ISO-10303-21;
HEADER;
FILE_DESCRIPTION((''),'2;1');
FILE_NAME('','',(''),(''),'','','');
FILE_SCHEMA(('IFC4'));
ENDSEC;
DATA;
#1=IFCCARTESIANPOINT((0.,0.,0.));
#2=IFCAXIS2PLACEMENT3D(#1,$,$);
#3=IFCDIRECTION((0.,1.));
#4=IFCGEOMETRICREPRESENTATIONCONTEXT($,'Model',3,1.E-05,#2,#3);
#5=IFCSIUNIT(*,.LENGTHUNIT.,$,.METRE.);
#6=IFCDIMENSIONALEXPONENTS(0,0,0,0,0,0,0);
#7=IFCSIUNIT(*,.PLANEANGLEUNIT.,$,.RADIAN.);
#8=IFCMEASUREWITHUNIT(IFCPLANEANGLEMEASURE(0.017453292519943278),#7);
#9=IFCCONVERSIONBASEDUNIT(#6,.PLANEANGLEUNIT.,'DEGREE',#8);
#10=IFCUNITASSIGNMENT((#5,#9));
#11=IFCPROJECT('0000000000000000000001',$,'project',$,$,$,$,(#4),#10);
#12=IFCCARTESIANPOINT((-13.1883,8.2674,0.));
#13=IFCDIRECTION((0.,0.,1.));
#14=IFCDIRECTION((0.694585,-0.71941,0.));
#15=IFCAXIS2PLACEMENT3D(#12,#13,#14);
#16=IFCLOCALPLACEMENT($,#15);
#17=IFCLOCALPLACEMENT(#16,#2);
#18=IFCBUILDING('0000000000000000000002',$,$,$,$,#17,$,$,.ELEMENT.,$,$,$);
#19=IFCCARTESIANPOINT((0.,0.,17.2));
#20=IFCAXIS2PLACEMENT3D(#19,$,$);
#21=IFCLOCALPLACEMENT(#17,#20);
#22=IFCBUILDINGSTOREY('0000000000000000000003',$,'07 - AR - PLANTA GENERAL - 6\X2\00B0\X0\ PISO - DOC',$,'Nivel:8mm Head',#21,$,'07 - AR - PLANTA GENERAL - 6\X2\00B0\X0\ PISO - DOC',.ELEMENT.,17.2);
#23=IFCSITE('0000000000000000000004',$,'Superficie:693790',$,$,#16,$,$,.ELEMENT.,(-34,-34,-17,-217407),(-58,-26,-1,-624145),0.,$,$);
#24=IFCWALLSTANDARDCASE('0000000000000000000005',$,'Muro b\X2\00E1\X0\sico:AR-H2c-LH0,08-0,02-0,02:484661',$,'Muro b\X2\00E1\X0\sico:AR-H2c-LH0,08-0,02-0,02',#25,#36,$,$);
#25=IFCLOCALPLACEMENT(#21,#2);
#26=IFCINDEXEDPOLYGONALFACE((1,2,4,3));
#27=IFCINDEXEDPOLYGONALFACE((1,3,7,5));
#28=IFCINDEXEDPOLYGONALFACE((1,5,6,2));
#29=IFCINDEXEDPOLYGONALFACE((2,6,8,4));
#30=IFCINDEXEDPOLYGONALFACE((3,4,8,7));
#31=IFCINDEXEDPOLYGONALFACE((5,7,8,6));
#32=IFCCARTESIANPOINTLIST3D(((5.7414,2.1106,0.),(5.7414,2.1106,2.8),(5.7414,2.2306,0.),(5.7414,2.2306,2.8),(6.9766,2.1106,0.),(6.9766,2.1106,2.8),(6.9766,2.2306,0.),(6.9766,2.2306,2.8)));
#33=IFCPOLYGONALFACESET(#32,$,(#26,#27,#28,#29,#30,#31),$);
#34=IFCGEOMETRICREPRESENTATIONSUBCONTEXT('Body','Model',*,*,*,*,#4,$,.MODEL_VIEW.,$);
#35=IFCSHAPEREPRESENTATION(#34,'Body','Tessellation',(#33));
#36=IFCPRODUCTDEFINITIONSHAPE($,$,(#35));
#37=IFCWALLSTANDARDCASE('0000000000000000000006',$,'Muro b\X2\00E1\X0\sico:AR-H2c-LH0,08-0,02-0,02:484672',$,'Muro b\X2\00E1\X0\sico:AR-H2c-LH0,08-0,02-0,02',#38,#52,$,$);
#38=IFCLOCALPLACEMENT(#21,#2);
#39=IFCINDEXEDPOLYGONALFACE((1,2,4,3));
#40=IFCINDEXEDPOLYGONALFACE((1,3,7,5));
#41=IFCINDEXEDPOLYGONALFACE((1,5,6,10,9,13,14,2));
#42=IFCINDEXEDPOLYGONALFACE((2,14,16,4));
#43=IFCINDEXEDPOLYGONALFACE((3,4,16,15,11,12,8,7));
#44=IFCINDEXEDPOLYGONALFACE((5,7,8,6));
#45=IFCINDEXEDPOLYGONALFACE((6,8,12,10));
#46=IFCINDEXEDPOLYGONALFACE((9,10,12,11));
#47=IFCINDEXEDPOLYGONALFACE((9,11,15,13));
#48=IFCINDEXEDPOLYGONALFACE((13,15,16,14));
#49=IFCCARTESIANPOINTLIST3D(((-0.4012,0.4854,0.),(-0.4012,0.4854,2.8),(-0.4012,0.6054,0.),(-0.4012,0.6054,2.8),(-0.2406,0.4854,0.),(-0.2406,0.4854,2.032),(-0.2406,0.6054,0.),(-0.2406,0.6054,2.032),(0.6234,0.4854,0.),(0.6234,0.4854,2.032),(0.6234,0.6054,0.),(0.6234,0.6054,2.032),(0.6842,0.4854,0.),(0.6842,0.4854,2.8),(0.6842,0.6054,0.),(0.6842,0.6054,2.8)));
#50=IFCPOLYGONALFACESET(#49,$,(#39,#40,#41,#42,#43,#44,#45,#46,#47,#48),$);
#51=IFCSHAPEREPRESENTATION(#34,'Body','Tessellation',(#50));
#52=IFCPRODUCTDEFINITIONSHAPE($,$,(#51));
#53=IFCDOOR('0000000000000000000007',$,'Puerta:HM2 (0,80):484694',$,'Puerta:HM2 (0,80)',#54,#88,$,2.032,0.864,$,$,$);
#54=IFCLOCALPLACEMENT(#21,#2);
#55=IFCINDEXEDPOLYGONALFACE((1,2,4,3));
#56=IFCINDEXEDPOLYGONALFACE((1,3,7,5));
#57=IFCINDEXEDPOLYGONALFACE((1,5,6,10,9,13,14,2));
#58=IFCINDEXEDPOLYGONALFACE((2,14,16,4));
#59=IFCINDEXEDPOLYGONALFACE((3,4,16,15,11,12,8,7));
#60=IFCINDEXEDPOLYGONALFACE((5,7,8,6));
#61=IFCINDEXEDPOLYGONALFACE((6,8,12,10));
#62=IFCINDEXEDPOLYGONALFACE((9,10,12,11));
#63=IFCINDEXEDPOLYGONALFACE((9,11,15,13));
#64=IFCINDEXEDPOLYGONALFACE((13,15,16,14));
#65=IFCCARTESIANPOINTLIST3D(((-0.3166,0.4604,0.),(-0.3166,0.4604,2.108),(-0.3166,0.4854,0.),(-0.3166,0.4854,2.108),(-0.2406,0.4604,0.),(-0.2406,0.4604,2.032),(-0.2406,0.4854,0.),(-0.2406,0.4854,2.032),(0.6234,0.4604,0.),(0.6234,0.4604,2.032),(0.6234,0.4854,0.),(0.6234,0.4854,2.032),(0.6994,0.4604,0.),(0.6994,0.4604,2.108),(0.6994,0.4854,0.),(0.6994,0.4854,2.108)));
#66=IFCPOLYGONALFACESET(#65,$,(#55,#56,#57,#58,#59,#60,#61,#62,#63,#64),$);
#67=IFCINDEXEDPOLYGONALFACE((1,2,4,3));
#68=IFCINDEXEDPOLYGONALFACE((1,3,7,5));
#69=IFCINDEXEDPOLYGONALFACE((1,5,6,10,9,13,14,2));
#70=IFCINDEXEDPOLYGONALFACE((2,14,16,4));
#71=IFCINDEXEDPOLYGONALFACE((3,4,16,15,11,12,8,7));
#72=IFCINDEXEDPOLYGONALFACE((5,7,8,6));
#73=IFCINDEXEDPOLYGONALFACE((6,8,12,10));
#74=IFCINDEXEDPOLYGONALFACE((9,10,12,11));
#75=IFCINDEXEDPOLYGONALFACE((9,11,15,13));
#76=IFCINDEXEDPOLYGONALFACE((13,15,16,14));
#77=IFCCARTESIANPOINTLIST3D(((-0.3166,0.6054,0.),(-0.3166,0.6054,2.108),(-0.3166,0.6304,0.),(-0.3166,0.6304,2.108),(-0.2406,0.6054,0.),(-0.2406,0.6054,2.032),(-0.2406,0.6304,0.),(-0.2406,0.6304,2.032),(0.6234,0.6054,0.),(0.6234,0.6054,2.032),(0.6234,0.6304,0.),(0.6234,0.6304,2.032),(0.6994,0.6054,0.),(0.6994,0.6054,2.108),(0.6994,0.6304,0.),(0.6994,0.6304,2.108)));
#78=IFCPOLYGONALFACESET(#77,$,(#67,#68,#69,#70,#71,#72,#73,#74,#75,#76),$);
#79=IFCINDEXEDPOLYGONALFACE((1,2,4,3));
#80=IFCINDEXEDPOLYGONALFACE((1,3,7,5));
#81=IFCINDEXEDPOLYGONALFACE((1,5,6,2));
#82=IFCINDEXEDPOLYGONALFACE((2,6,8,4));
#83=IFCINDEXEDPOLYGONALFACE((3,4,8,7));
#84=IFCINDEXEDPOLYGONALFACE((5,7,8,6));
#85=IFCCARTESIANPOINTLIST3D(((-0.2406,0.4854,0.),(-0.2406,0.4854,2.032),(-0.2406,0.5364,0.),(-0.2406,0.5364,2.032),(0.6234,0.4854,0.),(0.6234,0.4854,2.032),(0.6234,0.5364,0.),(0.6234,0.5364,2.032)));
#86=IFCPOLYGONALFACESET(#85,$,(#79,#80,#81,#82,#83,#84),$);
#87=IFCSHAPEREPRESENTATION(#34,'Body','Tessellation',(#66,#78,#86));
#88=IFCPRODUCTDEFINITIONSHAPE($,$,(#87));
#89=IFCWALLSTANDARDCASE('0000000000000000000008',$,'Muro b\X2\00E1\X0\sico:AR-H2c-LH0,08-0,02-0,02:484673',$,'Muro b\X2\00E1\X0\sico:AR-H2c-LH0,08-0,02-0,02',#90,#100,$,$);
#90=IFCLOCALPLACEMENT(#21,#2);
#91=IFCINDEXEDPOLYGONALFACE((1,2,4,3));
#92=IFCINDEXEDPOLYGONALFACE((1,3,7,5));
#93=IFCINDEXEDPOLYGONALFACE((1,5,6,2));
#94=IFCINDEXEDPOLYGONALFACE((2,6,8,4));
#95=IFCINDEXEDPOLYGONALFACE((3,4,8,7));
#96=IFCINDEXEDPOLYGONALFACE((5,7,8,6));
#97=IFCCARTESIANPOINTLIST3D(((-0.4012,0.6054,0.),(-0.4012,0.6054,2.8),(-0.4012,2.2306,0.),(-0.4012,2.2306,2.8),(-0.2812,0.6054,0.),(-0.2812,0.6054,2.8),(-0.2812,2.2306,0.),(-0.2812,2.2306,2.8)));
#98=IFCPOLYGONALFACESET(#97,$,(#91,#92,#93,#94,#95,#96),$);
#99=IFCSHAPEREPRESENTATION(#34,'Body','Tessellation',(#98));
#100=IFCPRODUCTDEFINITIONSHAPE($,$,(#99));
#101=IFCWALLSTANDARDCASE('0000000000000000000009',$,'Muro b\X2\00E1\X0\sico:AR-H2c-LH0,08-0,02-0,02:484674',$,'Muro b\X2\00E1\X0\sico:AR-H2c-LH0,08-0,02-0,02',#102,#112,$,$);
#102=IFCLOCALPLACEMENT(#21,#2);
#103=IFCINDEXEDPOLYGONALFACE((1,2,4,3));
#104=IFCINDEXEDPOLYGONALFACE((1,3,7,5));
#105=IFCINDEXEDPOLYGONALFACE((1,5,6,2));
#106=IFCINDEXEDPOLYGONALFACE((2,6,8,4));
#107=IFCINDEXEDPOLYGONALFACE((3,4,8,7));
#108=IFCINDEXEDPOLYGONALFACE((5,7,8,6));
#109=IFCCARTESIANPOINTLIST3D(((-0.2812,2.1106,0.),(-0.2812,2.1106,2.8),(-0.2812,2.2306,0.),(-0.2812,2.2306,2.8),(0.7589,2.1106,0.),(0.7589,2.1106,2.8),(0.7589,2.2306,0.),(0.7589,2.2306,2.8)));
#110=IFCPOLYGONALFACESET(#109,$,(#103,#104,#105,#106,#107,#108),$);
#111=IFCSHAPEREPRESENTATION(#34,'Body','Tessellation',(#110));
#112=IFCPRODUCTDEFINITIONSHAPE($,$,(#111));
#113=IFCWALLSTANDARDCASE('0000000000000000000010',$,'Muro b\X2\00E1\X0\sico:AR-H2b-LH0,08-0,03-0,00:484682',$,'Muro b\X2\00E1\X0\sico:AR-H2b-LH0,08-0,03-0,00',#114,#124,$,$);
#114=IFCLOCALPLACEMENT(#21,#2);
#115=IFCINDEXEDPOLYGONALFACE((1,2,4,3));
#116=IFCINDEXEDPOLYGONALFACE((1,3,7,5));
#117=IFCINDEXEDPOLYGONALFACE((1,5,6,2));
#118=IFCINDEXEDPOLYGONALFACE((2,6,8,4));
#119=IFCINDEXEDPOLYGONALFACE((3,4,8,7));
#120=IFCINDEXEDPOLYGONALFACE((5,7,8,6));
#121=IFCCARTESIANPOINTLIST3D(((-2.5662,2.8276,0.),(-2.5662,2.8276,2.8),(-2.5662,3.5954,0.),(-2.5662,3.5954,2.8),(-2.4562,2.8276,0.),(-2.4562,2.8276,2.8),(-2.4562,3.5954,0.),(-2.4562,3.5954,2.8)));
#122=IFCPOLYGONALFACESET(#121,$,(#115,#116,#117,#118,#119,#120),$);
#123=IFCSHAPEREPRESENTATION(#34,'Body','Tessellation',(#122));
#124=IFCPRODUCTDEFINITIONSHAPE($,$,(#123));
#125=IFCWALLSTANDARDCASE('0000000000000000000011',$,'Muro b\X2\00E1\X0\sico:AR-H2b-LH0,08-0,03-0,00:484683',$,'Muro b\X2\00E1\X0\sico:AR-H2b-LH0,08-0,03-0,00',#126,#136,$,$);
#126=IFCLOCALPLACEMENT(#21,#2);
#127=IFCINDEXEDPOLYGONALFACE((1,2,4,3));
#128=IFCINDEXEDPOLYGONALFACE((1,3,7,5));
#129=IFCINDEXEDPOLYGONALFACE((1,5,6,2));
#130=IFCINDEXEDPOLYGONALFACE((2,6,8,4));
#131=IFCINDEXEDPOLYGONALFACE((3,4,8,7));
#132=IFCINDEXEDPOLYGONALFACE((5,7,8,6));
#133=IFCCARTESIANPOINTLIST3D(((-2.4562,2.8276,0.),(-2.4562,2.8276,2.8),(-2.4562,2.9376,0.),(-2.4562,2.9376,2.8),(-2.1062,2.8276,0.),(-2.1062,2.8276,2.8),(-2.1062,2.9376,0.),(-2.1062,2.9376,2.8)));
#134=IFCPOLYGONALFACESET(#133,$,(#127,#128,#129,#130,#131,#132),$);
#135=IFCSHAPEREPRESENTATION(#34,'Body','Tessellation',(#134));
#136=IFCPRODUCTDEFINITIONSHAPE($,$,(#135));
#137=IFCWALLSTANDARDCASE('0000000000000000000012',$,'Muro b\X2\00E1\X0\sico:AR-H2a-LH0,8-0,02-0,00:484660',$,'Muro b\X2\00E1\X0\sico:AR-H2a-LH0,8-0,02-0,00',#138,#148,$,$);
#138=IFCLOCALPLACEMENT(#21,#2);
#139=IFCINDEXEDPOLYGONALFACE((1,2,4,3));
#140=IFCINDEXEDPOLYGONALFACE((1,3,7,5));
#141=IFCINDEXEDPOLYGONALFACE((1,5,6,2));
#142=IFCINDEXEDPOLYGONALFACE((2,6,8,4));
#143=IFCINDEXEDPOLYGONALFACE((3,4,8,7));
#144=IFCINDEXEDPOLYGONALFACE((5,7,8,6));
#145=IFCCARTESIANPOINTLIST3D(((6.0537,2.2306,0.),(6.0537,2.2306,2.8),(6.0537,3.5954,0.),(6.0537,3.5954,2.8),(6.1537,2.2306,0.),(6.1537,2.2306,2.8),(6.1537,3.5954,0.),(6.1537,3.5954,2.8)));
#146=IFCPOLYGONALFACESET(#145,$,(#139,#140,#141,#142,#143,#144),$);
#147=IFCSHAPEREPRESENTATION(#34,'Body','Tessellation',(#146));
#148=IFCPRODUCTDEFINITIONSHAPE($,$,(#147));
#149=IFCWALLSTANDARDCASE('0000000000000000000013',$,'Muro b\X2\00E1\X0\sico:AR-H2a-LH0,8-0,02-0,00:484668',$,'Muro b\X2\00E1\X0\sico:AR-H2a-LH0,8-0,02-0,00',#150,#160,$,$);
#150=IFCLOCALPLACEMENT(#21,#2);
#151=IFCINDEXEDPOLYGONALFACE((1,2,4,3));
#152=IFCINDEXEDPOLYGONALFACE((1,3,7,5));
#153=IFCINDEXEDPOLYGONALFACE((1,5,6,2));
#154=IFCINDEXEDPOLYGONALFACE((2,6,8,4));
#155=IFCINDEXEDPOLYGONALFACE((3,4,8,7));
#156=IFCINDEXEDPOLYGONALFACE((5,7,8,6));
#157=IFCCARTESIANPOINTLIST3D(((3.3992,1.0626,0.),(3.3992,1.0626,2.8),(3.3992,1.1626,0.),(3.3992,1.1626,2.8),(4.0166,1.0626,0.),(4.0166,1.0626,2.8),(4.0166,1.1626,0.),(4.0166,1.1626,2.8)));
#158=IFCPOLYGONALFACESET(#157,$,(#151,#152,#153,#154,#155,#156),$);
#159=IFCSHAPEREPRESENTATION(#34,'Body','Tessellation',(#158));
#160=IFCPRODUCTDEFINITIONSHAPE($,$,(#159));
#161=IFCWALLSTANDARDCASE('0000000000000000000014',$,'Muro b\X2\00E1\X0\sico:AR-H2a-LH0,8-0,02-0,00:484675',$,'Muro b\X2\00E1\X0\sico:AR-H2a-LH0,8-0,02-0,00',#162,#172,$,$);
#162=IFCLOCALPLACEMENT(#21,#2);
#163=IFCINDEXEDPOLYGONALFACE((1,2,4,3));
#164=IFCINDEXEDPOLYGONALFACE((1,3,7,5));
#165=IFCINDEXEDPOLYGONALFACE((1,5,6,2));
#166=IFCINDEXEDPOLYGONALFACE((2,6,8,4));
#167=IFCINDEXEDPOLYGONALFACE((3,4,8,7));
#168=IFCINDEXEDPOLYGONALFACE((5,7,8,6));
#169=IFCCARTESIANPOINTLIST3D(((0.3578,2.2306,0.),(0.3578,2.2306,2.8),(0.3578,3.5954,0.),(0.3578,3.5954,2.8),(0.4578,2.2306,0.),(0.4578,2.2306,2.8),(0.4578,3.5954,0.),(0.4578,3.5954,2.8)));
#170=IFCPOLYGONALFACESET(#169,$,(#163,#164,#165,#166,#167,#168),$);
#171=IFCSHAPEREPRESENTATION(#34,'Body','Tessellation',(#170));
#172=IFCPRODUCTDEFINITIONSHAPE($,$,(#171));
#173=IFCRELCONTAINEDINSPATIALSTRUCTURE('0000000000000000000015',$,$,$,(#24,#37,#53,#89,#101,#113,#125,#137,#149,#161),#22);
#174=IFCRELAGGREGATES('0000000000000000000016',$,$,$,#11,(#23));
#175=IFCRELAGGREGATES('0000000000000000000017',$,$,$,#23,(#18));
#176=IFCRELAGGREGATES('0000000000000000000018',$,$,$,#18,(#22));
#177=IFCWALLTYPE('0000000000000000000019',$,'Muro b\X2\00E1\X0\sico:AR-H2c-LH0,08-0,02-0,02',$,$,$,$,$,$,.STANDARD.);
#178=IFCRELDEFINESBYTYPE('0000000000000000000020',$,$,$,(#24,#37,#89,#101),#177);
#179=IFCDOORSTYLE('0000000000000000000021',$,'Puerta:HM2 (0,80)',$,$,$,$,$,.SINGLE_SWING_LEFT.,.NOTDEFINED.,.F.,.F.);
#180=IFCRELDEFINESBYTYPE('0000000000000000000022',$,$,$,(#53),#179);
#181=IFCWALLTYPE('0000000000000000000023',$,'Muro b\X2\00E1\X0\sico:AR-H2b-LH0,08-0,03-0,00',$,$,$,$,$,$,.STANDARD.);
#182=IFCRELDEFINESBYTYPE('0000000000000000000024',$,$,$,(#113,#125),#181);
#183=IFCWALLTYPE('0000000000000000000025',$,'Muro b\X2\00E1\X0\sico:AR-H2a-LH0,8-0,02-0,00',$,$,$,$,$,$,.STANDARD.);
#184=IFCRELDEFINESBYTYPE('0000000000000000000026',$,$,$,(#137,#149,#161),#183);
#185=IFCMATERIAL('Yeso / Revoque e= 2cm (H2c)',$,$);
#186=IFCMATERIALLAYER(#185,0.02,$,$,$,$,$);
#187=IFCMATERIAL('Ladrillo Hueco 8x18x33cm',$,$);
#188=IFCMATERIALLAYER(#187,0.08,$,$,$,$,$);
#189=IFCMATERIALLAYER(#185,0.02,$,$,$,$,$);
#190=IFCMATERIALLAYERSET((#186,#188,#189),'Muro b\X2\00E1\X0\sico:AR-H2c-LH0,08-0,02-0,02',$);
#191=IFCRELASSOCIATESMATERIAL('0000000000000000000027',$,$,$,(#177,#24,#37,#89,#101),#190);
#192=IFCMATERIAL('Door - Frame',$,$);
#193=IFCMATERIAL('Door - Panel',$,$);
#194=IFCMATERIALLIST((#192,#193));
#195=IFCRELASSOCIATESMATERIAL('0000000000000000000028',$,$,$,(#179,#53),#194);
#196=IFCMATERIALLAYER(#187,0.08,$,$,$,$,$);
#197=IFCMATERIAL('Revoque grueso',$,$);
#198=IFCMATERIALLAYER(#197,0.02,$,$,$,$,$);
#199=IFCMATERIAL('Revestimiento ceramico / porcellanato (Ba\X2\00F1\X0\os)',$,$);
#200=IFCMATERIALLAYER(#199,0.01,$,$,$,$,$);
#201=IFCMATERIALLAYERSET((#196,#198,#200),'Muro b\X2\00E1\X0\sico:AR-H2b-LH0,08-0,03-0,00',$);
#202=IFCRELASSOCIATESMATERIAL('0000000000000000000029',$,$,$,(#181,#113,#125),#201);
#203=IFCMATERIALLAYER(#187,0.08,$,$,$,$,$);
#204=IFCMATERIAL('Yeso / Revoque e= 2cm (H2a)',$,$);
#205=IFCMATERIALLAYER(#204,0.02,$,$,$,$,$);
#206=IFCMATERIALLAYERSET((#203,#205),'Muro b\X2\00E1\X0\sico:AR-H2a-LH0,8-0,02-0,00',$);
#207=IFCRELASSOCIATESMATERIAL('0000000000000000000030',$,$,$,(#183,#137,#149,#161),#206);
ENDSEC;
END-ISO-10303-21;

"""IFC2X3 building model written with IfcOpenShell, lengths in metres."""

from ifc_helpers import new_model, entity, si_unit, converted_unit, direction, frame, frame_2d, origin, origin_2d_with_axis, place, context, subcontext, project, spatial, polyline, rectangle, outline, extrude, source, transform, mapped, material, material_list, layer, layer_set, layer_usage, type_object, type_shapes, element, fill, save


model = new_model("IFC2X3")

# Units and contexts
model_context = context("Model", 3, precision=1e-05, world=origin(), true_north=direction((0.0, 1.0)))
body_context = subcontext(model_context, "Body", "Model", "MODEL_VIEW")
ifc_project = project(units=[si_unit("LENGTHUNIT", "METRE"), converted_unit("PLANEANGLEUNIT", "DEGREE", entity("IfcPlaneAngleMeasure", 0.017453292519943278), si_unit("PLANEANGLEUNIT", "RADIAN"), dimensions=[0, 0, 0, 0, 0, 0, 0])], contexts=[model_context])

# Site, building, storey
site_placement = place(None, frame((-13.1883, 8.2674, 0.0), z_axis=(0.0, 0.0, 1.0), x_axis=(0.694585, -0.71941, 0.0)))
site = spatial("IfcSite", under=ifc_project, at=site_placement, Name="Superficie:693790", CompositionType="ELEMENT", RefLatitude=(-34, -34, -17, -217407), RefLongitude=(-58, -26, -1, -624145), RefElevation=0.0)
building_placement = place(site_placement, origin())
building = spatial("IfcBuilding", under=site, at=building_placement, CompositionType="ELEMENT")
storey_placement = place(building_placement, frame((0.0, 0.0, 17.2)))
storey = spatial("IfcBuildingStorey", under=building, at=storey_placement, Name="07 - AR - PLANTA GENERAL - 6° PISO - DOC", ObjectType="Nivel:8mm Head", LongName="07 - AR - PLANTA GENERAL - 6° PISO - DOC", CompositionType="ELEMENT", Elevation=17.2)

# Wall
ifc_material_1 = material(Name="Yeso / Revoque e= 2cm (H2c)")
ifc_layer_1 = layer(ifc_material_1, 0.02)
ifc_material_2 = material(Name="Ladrillo Hueco 8x18x33cm")
ifc_layer_2 = layer(ifc_material_2, 0.08)
ifc_layer_3 = layer(ifc_material_1, 0.02)
ifc_layer_set_1 = layer_set([ifc_layer_1, ifc_layer_2, ifc_layer_3], Name="Muro básico:AR-H2c-LH0,08-0,02-0,02")
ifc_layer_usage_1 = layer_usage(ifc_layer_set_1, "AXIS2", "NEGATIVE", 0.06)
wall_type_1 = type_object("IfcWallType", Name="Muro básico:AR-H2c-LH0,08-0,02-0,02", PredefinedType="STANDARD", material=ifc_layer_set_1)
wall_1_placement = place(storey_placement, frame((5.7414, 2.1706, 0.0)))
element("IfcWallStandardCase", 1, at=wall_1_placement, inside=storey, type_object=wall_type_1, material=ifc_layer_usage_1, Name="Muro básico:AR-H2c-LH0,08-0,02-0,02:484661", ObjectType="Muro básico:AR-H2c-LH0,08-0,02-0,02", context=body_context, shape_type="SweptSolid", body=[
    extrude(rectangle(XDim=1.2352, YDim=0.12, at=frame_2d((0.6176, 0.0), x_axis=(-1.0, 0.0))), origin(), (0.0, 0.0, 1.0), 2.8),
])

# Wall, opening, door
ifc_layer_usage_2 = layer_usage(ifc_layer_set_1, "AXIS2", "POSITIVE", -0.06)
wall_2_placement = place(storey_placement, frame((-0.4012, 0.5454, 0.0)))
wall_2 = element("IfcWallStandardCase", 2, at=wall_2_placement, inside=storey, type_object=wall_type_1, material=ifc_layer_usage_2, Name="Muro básico:AR-H2c-LH0,08-0,02-0,02:484672", ObjectType="Muro básico:AR-H2c-LH0,08-0,02-0,02", context=body_context, shape_type="SweptSolid", body=[
    extrude(rectangle(XDim=1.0854, YDim=0.12, at=frame_2d((0.5427, 0.0), x_axis=(1.0, 0.0))), origin(), (0.0, 0.0, 1.0), 2.8),
])
opening_placement = place(wall_2_placement, frame((1.0246, 0.06, 0.0)))
opening = element("IfcOpeningElement", 3, at=opening_placement, cuts=wall_2, ObjectType="Opening", context=body_context, shape_type="SweptSolid", body=[
    extrude(rectangle(XDim=0.864, YDim=2.032, at=frame_2d((1.016, 0.432), x_axis=(0.0, -1.0))), frame((0.0, 0.0, 0.0), z_axis=(0.0, -1.0, 0.0), x_axis=(0.0, 0.0, 1.0)), (0.0, 0.0, 1.0), 0.12),
])
ifc_material_3 = material(Name="Door - Frame")
ifc_material_4 = material(Name="Door - Panel")
ifc_material_list = material_list([ifc_material_3, ifc_material_4])
door_style = type_object("IfcDoorStyle", Name="Puerta:HM2 (0,80)", ConstructionType="NOTDEFINED", OperationType="SINGLE_SWING_LEFT", ParameterTakesPrecedence=False, Sizeable=False, material=ifc_material_list)
shared_shape_1 = source(origin(), body_context, "Body", "SweptSolid", [
    extrude(outline(polyline([(-0.508, -1.073), (0.508, -1.073), (0.508, 1.035), (0.432, 1.035), (0.432, -0.997), (-0.432, -0.997), (-0.432, 1.035), (-0.508, 1.035), (-0.508, -1.073)])), frame((0.432, 0.145, 1.035), z_axis=(0.0, -1.0, 0.0), x_axis=(-1.0, 0.0, 0.0)), (0.0, 0.0, 1.0), 0.025),
    extrude(outline(polyline([(-1.073, -0.508), (1.035, -0.508), (1.035, -0.432), (-0.997, -0.432), (-0.997, 0.432), (1.035, 0.432), (1.035, 0.508), (-1.073, 0.508), (-1.073, -0.508)])), frame((0.432, 0.0, 1.035), z_axis=(0.0, -1.0, 0.0), x_axis=(0.0, 0.0, -1.0)), (0.0, 0.0, 1.0), 0.025),
    extrude(rectangle(XDim=0.864, YDim=0.051, at=origin_2d_with_axis()), frame((0.432, 0.0945, 0.0)), (0.0, 0.0, 1.0), 2.032),
])
type_shapes(door_style, [shared_shape_1])
door_placement = place(opening_placement, frame((0.0, 0.0, 0.0), z_axis=(0.0, 0.0, 1.0), x_axis=(-1.0, 0.0, 0.0)))
door = element("IfcDoor", 4, at=door_placement, inside=storey, type_object=door_style, material=ifc_material_list, Name="Puerta:HM2 (0,80):484694", ObjectType="Puerta:HM2 (0,80)", OverallHeight=2.032, OverallWidth=0.864, context=body_context, shape_type="MappedRepresentation", body=[
    mapped(shared_shape_1, transform((0.0, 0.0, 0.0), scale=1.0)),
])
fill(opening, door)

# Walls
ifc_layer_usage_3 = layer_usage(ifc_layer_set_1, "AXIS2", "NEGATIVE", 0.06)
wall_3_placement = place(storey_placement, frame((-0.3412, 0.6054, 0.0), z_axis=(0.0, 0.0, 1.0), x_axis=(0.0, 1.0, 0.0)))
element("IfcWallStandardCase", 5, at=wall_3_placement, inside=storey, type_object=wall_type_1, material=ifc_layer_usage_3, Name="Muro básico:AR-H2c-LH0,08-0,02-0,02:484673", ObjectType="Muro básico:AR-H2c-LH0,08-0,02-0,02", context=body_context, shape_type="SweptSolid", body=[
    extrude(rectangle(XDim=1.6252, YDim=0.12, at=frame_2d((0.8126, 0.0), x_axis=(-1.0, 0.0))), origin(), (0.0, 0.0, 1.0), 2.8),
])
ifc_layer_usage_4 = layer_usage(ifc_layer_set_1, "AXIS2", "NEGATIVE", 0.06)
wall_4_placement = place(storey_placement, frame((-0.2812, 2.1706, 0.0)))
element("IfcWallStandardCase", 6, at=wall_4_placement, inside=storey, type_object=wall_type_1, material=ifc_layer_usage_4, Name="Muro básico:AR-H2c-LH0,08-0,02-0,02:484674", ObjectType="Muro básico:AR-H2c-LH0,08-0,02-0,02", context=body_context, shape_type="SweptSolid", body=[
    extrude(rectangle(XDim=1.0402, YDim=0.12, at=frame_2d((0.5201, 0.0), x_axis=(-1.0, 0.0))), origin(), (0.0, 0.0, 1.0), 2.8),
])
ifc_layer_4 = layer(ifc_material_2, 0.08)
ifc_material_5 = material(Name="Revoque grueso")
ifc_layer_5 = layer(ifc_material_5, 0.02)
ifc_material_6 = material(Name="Revestimiento ceramico / porcellanato (Baños)")
ifc_layer_6 = layer(ifc_material_6, 0.01)
ifc_layer_set_2 = layer_set([ifc_layer_4, ifc_layer_5, ifc_layer_6], Name="Muro básico:AR-H2b-LH0,08-0,03-0,00")
ifc_layer_usage_5 = layer_usage(ifc_layer_set_2, "AXIS2", "POSITIVE", -0.055)
wall_type_2 = type_object("IfcWallType", Name="Muro básico:AR-H2b-LH0,08-0,03-0,00", PredefinedType="STANDARD", material=ifc_layer_set_2)
wall_5_placement = place(storey_placement, frame((-2.5112, 2.8276, 0.0), z_axis=(0.0, 0.0, 1.0), x_axis=(0.0, 1.0, 0.0)))
element("IfcWallStandardCase", 7, at=wall_5_placement, inside=storey, type_object=wall_type_2, material=ifc_layer_usage_5, Name="Muro básico:AR-H2b-LH0,08-0,03-0,00:484682", ObjectType="Muro básico:AR-H2b-LH0,08-0,03-0,00", context=body_context, shape_type="SweptSolid", body=[
    extrude(rectangle(XDim=0.7678, YDim=0.11, at=frame_2d((0.3839, 0.0), x_axis=(-1.0, 0.0))), origin(), (0.0, 0.0, 1.0), 2.8),
])
ifc_layer_usage_6 = layer_usage(ifc_layer_set_2, "AXIS2", "POSITIVE", -0.055)
wall_6_placement = place(storey_placement, frame((-2.1062, 2.8826, 0.0), z_axis=(0.0, 0.0, 1.0), x_axis=(-1.0, 0.0, 0.0)))
element("IfcWallStandardCase", 8, at=wall_6_placement, inside=storey, type_object=wall_type_2, material=ifc_layer_usage_6, Name="Muro básico:AR-H2b-LH0,08-0,03-0,00:484683", ObjectType="Muro básico:AR-H2b-LH0,08-0,03-0,00", context=body_context, shape_type="SweptSolid", body=[
    extrude(rectangle(XDim=0.35, YDim=0.11, at=frame_2d((0.175, 0.0), x_axis=(-1.0, 0.0))), origin(), (0.0, 0.0, 1.0), 2.8),
])
ifc_layer_7 = layer(ifc_material_2, 0.08)
ifc_material_7 = material(Name="Yeso / Revoque e= 2cm (H2a)")
ifc_layer_8 = layer(ifc_material_7, 0.02)
ifc_layer_set_3 = layer_set([ifc_layer_7, ifc_layer_8], Name="Muro básico:AR-H2a-LH0,8-0,02-0,00")
ifc_layer_usage_7 = layer_usage(ifc_layer_set_3, "AXIS2", "POSITIVE", -0.05)
wall_type_3 = type_object("IfcWallType", Name="Muro básico:AR-H2a-LH0,8-0,02-0,00", PredefinedType="STANDARD", material=ifc_layer_set_3)
wall_7_placement = place(storey_placement, frame((6.1037, 3.5954, 0.0), z_axis=(0.0, 0.0, 1.0), x_axis=(0.0, -1.0, 0.0)))
element("IfcWallStandardCase", 9, at=wall_7_placement, inside=storey, type_object=wall_type_3, material=ifc_layer_usage_7, Name="Muro básico:AR-H2a-LH0,8-0,02-0,00:484660", ObjectType="Muro básico:AR-H2a-LH0,8-0,02-0,00", context=body_context, shape_type="SweptSolid", body=[
    extrude(rectangle(XDim=1.3648, YDim=0.1, at=frame_2d((0.6824, 0.0), x_axis=(-1.0, 0.0))), origin(), (0.0, 0.0, 1.0), 2.8),
])
ifc_layer_usage_8 = layer_usage(ifc_layer_set_3, "AXIS2", "POSITIVE", -0.05)
wall_8_placement = place(storey_placement, frame((4.0166, 1.1126, 0.0), z_axis=(0.0, 0.0, 1.0), x_axis=(-1.0, 0.0, 0.0)))
element("IfcWallStandardCase", 10, at=wall_8_placement, inside=storey, type_object=wall_type_3, material=ifc_layer_usage_8, Name="Muro básico:AR-H2a-LH0,8-0,02-0,00:484668", ObjectType="Muro básico:AR-H2a-LH0,8-0,02-0,00", context=body_context, shape_type="SweptSolid", body=[
    extrude(rectangle(XDim=0.6175, YDim=0.1, at=frame_2d((0.3087, 0.0), x_axis=(-1.0, 0.0))), origin(), (0.0, 0.0, 1.0), 2.8),
])
ifc_layer_usage_9 = layer_usage(ifc_layer_set_3, "AXIS2", "NEGATIVE", 0.05)
wall_9_placement = place(storey_placement, frame((0.4078, 3.5954, 0.0), z_axis=(0.0, 0.0, 1.0), x_axis=(0.0, -1.0, 0.0)))
element("IfcWallStandardCase", 11, at=wall_9_placement, inside=storey, type_object=wall_type_3, material=ifc_layer_usage_9, Name="Muro básico:AR-H2a-LH0,8-0,02-0,00:484675", ObjectType="Muro básico:AR-H2a-LH0,8-0,02-0,00", context=body_context, shape_type="SweptSolid", body=[
    extrude(rectangle(XDim=1.3648, YDim=0.1, at=frame_2d((0.6824, 0.0), x_axis=(-1.0, 0.0))), origin(), (0.0, 0.0, 1.0), 2.8),
])

save(model, "model.ifc")
